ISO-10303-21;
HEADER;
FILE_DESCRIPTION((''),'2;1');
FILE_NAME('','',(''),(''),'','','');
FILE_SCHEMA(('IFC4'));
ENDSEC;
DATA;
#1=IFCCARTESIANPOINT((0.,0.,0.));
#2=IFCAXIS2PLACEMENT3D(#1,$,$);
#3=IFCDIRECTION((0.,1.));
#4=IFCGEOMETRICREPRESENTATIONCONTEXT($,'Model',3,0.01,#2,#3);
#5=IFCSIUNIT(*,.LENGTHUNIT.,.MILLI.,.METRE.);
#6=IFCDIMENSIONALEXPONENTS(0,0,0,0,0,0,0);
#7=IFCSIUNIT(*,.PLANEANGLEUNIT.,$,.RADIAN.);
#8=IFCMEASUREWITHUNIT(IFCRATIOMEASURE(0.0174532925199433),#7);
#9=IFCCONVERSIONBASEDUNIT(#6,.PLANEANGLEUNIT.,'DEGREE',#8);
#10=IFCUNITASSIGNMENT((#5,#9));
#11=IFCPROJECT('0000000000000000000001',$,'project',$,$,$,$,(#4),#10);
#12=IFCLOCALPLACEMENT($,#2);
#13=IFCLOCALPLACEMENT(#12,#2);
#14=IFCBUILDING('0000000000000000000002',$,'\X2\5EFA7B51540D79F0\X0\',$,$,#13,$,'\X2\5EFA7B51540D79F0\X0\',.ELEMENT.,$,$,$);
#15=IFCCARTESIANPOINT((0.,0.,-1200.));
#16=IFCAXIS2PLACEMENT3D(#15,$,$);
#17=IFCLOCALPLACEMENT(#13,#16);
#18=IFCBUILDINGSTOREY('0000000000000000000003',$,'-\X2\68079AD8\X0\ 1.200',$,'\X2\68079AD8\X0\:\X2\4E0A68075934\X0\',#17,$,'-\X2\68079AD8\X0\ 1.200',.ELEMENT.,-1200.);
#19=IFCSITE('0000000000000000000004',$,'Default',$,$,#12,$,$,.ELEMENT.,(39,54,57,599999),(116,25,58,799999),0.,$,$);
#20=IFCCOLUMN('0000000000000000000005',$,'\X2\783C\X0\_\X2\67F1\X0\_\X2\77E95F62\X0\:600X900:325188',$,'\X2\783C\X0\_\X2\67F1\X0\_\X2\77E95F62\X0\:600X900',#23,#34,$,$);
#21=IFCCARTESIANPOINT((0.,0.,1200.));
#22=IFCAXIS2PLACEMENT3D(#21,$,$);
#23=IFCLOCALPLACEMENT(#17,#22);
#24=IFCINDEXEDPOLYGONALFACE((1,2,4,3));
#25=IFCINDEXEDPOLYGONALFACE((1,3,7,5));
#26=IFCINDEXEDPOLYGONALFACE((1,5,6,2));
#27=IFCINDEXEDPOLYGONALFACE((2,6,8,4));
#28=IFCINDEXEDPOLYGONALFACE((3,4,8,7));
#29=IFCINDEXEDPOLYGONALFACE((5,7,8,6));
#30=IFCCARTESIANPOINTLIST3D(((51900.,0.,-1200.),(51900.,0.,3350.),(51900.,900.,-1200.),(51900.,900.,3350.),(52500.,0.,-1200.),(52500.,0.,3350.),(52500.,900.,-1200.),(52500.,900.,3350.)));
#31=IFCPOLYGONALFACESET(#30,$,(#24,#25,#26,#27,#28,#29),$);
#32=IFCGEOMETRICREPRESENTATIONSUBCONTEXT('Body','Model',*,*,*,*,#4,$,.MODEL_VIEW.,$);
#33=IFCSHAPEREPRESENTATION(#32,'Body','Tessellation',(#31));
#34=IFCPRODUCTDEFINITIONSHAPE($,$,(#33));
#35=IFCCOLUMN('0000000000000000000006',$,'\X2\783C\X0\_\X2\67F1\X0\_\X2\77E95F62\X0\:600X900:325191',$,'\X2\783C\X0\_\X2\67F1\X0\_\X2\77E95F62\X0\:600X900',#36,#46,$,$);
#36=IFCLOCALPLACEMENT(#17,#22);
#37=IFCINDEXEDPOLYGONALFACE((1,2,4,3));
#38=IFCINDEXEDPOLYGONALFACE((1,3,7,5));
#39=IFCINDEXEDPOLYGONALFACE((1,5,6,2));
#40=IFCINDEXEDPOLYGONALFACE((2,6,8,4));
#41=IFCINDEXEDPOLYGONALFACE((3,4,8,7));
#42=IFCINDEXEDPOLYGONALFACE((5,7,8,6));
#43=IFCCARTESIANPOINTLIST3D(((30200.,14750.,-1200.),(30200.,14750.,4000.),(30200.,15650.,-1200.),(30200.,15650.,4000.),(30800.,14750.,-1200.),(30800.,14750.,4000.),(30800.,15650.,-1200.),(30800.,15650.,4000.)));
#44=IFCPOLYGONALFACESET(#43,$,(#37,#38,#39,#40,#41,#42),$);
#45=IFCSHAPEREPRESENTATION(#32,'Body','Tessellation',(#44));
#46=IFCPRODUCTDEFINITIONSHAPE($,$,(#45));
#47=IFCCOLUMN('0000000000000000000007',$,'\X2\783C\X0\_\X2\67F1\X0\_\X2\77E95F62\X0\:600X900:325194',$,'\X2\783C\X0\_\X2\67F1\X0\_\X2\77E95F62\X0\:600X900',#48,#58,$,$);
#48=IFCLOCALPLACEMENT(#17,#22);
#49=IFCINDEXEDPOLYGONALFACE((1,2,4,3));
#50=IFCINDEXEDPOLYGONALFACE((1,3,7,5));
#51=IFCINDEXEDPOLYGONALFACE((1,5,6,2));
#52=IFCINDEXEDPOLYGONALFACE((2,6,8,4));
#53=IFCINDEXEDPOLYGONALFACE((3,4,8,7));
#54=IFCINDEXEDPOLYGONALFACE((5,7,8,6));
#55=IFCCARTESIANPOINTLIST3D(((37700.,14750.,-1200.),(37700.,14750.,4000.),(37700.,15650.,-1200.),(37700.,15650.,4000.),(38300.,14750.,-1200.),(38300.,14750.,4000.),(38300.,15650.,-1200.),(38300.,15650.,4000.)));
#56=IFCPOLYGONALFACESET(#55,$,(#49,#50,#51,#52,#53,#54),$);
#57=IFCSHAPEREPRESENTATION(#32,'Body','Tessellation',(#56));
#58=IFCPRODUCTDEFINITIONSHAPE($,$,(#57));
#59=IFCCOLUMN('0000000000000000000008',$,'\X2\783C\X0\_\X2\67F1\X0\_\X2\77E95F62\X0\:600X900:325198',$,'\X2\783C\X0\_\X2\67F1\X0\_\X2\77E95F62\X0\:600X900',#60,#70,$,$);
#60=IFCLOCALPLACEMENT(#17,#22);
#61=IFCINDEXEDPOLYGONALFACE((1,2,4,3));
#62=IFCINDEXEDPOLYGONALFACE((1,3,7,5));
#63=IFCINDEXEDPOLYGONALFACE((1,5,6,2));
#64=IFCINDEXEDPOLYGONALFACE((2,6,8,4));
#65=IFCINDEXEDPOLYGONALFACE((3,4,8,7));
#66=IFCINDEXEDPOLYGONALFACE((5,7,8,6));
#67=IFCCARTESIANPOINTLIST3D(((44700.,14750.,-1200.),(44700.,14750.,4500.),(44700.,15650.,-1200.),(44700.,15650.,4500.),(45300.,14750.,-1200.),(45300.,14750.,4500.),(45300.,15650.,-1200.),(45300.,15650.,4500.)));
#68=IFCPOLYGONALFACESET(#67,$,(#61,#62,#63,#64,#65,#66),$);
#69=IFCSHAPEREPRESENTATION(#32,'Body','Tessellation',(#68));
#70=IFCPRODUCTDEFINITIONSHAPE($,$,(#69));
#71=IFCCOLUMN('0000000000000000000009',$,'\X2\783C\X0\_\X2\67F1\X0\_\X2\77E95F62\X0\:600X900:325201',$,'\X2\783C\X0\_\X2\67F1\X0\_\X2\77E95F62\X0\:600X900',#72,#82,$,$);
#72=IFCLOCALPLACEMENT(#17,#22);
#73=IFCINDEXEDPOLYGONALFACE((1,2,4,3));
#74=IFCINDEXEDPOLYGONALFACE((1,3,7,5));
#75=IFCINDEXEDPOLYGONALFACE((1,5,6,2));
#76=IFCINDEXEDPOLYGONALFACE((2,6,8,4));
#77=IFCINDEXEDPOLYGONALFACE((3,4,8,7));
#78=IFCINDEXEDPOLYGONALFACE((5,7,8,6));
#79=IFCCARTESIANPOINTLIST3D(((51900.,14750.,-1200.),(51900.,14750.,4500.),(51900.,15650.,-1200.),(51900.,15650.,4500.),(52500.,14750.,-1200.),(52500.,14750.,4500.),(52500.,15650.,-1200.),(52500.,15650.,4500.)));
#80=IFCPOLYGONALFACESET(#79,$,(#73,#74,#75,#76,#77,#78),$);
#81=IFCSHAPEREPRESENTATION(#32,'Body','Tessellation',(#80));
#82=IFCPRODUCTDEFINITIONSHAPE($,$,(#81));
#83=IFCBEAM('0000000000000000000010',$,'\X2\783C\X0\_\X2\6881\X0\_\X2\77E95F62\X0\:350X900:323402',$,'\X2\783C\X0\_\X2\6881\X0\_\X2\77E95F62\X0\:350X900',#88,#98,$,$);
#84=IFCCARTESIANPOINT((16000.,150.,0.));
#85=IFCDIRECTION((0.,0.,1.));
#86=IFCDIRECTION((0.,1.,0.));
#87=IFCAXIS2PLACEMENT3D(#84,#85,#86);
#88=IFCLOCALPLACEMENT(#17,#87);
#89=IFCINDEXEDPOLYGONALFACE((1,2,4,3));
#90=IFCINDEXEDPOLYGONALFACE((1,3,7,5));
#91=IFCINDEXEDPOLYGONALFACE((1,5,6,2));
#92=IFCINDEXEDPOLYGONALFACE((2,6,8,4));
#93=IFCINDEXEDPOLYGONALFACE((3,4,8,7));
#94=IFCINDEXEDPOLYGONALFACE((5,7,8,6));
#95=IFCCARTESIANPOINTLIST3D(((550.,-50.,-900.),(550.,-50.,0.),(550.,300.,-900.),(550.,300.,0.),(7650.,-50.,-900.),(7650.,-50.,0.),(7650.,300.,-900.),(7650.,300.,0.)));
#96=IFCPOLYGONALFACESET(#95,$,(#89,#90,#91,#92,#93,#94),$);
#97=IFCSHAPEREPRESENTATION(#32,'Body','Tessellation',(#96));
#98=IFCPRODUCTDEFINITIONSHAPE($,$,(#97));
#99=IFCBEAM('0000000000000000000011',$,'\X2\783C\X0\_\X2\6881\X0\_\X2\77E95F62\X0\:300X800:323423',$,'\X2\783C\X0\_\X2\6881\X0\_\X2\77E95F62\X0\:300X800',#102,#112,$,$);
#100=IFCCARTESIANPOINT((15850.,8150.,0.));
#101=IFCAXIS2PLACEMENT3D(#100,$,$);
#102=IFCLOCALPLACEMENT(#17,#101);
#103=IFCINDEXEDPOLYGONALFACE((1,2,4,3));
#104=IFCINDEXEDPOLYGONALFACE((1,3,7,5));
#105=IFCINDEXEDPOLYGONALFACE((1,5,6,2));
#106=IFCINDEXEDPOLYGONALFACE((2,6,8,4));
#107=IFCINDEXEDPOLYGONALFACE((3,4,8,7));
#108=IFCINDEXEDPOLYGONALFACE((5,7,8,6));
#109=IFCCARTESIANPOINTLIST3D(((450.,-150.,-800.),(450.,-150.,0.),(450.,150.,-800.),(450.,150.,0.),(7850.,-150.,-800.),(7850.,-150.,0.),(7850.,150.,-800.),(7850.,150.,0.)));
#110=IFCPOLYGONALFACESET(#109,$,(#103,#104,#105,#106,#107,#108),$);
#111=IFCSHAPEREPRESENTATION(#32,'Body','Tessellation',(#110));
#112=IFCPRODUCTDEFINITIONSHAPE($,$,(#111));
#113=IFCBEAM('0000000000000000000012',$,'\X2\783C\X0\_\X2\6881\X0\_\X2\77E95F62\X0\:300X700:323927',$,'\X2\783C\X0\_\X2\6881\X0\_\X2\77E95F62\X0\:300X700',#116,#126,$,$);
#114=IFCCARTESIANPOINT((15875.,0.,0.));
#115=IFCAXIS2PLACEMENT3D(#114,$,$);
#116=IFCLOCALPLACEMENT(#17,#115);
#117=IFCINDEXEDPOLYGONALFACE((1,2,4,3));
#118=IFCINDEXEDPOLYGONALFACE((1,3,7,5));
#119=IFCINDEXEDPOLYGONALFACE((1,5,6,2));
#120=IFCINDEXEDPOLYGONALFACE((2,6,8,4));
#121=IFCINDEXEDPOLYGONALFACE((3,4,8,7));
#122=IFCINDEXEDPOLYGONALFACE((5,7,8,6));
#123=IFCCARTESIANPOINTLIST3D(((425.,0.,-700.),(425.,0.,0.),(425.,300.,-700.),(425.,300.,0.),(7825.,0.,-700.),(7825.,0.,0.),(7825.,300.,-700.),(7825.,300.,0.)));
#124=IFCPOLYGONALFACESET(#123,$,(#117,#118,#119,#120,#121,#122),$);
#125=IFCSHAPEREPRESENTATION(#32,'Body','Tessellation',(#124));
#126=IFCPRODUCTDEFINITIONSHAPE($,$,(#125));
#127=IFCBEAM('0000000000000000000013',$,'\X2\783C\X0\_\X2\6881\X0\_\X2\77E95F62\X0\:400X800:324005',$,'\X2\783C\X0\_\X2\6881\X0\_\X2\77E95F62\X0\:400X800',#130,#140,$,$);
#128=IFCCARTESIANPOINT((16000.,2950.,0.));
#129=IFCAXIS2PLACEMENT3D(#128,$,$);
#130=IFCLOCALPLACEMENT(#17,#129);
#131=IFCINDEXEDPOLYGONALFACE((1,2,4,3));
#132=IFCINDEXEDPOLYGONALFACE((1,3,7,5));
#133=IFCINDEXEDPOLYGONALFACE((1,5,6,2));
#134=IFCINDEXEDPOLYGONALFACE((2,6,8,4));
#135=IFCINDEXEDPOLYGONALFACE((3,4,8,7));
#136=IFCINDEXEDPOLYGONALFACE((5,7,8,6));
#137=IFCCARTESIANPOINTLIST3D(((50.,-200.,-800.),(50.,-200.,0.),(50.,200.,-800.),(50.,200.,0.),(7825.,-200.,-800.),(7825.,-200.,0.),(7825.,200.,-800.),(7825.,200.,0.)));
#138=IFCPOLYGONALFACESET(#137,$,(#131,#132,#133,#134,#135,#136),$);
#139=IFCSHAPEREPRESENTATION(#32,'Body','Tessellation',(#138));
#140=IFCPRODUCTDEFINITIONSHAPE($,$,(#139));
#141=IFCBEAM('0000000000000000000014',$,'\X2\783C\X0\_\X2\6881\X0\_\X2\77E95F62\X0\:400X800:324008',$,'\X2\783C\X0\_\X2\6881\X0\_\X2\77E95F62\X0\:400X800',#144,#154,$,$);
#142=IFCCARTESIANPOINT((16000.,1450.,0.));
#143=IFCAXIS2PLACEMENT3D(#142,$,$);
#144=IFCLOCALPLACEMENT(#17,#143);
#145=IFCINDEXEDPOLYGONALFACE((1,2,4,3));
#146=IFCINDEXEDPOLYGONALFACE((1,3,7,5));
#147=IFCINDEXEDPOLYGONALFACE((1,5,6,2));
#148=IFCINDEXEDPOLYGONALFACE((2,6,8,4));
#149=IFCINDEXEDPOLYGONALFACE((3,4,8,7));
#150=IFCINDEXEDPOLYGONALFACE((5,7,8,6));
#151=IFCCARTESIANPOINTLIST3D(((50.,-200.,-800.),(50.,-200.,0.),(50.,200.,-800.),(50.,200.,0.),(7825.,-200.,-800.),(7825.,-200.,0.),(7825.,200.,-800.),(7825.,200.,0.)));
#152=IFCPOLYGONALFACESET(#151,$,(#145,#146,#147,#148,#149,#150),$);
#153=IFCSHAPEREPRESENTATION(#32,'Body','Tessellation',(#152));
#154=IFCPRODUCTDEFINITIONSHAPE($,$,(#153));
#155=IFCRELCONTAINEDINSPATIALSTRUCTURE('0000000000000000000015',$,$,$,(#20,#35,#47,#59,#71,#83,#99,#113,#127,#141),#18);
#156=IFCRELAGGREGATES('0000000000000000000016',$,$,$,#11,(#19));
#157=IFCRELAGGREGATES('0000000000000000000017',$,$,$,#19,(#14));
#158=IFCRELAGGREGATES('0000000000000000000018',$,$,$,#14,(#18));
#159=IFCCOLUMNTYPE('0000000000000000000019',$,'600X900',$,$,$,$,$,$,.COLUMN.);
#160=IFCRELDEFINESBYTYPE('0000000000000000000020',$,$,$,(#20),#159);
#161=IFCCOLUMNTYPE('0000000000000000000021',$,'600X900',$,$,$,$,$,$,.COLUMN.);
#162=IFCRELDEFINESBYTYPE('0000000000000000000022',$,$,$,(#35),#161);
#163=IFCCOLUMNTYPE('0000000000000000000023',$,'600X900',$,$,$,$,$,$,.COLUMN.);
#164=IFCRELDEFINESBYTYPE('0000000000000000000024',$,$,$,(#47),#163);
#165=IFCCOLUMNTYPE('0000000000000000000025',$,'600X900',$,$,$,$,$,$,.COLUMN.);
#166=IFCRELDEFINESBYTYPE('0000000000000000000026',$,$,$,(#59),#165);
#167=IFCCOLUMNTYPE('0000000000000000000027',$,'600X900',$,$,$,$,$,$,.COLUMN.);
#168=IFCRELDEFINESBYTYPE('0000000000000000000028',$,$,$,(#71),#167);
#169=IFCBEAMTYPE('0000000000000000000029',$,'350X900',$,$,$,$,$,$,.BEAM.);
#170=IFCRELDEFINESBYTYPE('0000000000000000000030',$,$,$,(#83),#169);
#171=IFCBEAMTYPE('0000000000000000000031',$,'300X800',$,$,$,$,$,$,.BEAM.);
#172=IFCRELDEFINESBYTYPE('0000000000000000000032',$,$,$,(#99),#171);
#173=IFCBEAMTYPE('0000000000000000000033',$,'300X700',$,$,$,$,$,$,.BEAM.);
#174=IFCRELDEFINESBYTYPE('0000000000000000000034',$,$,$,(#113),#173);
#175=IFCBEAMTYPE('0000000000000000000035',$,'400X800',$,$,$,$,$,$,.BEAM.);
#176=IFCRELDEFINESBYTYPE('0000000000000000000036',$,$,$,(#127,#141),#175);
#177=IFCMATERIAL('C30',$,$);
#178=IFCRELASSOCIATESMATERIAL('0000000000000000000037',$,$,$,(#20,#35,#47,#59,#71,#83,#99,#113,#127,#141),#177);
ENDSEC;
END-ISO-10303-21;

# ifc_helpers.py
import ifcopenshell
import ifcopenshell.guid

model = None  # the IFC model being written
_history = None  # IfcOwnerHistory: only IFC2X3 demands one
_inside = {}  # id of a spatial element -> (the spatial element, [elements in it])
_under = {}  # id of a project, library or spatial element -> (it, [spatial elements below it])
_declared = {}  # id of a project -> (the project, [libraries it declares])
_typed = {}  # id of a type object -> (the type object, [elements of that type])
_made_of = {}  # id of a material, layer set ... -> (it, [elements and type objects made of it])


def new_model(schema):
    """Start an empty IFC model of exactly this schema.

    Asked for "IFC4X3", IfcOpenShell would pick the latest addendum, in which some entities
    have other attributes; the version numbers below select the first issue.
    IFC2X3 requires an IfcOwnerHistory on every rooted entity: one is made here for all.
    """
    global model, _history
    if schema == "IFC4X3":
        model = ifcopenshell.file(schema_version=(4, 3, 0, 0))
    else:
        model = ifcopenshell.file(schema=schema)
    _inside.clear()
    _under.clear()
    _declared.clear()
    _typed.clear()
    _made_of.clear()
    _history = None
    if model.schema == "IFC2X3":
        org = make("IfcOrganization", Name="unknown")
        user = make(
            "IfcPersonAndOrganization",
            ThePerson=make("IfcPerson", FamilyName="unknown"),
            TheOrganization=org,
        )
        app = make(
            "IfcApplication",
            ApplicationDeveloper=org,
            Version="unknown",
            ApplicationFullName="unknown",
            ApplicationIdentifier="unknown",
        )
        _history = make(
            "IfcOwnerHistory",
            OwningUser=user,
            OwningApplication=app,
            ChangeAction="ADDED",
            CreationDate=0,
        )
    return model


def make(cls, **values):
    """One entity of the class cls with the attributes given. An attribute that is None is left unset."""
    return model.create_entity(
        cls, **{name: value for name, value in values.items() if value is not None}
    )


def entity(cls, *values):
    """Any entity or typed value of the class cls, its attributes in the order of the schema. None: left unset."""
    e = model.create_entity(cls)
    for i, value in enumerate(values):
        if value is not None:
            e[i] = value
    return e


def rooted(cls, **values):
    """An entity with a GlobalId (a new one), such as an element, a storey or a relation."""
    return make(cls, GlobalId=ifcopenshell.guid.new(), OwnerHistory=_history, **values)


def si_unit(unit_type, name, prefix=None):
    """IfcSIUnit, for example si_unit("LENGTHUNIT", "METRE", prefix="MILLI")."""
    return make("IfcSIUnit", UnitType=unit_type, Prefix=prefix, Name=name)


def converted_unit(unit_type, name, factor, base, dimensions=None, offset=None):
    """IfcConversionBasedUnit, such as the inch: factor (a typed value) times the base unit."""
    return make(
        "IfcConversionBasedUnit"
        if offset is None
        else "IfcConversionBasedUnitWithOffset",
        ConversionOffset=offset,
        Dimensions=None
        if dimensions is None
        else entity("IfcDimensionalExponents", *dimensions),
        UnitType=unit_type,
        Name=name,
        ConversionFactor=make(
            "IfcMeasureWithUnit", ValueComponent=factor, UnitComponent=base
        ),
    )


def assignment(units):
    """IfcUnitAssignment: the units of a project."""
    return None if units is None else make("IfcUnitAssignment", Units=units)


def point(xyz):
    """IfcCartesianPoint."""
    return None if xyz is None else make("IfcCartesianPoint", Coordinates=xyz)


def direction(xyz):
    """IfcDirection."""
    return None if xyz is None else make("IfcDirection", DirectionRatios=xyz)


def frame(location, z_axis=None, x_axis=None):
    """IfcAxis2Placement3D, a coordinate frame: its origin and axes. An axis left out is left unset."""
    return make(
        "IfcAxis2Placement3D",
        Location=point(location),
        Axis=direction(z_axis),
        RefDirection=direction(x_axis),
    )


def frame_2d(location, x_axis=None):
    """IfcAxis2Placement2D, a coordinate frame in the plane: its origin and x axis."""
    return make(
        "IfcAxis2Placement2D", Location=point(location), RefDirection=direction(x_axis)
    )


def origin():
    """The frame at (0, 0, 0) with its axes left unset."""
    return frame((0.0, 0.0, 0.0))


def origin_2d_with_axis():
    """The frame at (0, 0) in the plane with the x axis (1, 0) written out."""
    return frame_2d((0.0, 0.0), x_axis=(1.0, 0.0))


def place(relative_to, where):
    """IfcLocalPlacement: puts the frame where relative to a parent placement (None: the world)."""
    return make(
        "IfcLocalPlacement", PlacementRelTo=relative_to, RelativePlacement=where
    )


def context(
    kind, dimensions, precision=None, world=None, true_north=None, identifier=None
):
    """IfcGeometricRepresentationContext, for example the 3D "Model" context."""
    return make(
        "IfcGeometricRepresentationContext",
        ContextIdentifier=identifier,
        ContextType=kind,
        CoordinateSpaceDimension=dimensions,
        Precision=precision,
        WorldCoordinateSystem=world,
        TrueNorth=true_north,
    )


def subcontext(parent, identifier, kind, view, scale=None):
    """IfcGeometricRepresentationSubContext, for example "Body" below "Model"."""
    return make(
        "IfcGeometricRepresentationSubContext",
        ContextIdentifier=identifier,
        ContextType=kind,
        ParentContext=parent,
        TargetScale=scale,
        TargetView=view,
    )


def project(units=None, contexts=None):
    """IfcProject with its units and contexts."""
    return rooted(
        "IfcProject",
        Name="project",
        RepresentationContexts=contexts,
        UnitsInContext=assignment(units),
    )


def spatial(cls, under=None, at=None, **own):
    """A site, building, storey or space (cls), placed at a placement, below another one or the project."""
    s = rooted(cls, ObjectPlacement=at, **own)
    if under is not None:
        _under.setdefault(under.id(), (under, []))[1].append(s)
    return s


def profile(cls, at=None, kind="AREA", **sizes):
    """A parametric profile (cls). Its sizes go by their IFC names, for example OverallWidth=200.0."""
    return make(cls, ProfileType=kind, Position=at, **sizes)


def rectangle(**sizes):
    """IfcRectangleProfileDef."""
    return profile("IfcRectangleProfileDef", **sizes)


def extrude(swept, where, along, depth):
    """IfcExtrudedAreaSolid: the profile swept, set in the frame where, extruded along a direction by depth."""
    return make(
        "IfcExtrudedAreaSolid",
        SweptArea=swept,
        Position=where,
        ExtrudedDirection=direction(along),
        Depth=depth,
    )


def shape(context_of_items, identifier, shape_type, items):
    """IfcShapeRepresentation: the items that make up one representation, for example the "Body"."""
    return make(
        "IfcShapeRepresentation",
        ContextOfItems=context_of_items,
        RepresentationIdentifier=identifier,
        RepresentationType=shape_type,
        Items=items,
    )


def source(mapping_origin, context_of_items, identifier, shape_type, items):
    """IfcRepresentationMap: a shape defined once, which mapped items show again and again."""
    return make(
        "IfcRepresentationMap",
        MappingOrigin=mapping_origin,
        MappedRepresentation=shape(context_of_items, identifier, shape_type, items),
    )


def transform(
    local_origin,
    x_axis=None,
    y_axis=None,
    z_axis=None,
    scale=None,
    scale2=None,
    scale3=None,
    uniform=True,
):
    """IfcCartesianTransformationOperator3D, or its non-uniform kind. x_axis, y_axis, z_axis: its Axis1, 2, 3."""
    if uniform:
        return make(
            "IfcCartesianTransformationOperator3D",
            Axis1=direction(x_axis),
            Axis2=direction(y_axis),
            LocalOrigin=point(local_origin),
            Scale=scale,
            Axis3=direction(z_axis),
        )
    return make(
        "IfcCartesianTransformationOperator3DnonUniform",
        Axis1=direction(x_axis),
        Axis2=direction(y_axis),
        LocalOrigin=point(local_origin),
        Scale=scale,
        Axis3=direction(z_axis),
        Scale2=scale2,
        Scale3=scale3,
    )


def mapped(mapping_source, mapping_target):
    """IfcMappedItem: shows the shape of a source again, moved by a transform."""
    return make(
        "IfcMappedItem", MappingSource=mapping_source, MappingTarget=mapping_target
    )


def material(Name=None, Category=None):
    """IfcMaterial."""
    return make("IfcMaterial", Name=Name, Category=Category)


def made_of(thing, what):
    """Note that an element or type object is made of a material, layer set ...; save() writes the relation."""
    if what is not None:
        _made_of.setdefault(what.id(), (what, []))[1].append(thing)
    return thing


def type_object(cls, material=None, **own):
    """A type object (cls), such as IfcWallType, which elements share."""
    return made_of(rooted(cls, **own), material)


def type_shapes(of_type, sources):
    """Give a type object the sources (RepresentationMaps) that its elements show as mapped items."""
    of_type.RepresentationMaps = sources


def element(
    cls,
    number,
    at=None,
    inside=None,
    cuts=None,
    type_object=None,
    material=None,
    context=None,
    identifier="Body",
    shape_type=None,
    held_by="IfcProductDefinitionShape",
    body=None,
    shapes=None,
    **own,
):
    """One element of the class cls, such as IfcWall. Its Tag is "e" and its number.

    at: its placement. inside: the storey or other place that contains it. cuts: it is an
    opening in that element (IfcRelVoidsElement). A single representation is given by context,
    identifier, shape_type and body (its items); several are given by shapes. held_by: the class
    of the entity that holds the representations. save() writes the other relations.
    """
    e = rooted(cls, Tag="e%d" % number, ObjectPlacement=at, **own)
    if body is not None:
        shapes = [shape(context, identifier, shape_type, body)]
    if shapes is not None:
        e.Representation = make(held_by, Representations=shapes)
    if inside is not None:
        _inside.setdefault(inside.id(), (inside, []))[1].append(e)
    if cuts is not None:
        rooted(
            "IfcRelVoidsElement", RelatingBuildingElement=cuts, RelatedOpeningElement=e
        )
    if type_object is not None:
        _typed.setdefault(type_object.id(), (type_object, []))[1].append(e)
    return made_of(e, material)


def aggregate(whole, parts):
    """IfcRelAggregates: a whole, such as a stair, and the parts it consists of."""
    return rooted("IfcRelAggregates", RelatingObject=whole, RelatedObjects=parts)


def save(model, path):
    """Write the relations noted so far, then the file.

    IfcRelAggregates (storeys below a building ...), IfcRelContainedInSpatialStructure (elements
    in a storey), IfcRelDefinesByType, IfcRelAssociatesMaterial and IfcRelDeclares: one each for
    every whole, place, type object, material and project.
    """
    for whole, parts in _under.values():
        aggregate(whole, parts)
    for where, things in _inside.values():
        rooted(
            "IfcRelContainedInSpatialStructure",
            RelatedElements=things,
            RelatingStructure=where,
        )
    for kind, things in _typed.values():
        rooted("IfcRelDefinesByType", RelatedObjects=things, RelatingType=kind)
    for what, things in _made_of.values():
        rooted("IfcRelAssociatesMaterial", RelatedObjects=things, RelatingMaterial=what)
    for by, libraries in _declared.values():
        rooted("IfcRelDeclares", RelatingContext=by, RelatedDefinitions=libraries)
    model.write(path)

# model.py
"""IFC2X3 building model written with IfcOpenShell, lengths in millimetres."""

from ifc_helpers import new_model, entity, si_unit, converted_unit, direction, frame, frame_2d, origin, origin_2d_with_axis, place, context, subcontext, project, spatial, rectangle, extrude, source, transform, mapped, material, type_object, type_shapes, element, save


model = new_model("IFC2X3")

# Units and contexts
model_context = context("Model", 3, precision=0.01, world=origin(), true_north=direction((0.0, 1.0)))
body_context = subcontext(model_context, "Body", "Model", "MODEL_VIEW")
ifc_project = project(units=[si_unit("LENGTHUNIT", "METRE", prefix="MILLI"), converted_unit("PLANEANGLEUNIT", "DEGREE", entity("IfcRatioMeasure", 0.0174532925199433), si_unit("PLANEANGLEUNIT", "RADIAN"), dimensions=[0, 0, 0, 0, 0, 0, 0])], contexts=[model_context])

# Site, building, storey
site_placement = place(None, origin())
site = spatial("IfcSite", under=ifc_project, at=site_placement, Name="Default", CompositionType="ELEMENT", RefLatitude=(39, 54, 57, 599999), RefLongitude=(116, 25, 58, 799999), RefElevation=0.0)
building_placement = place(site_placement, origin())
building = spatial("IfcBuilding", under=site, at=building_placement, Name="建筑名称", LongName="建筑名称", CompositionType="ELEMENT")
storey_placement = place(building_placement, frame((0.0, 0.0, -1200.0)))
storey = spatial("IfcBuildingStorey", under=building, at=storey_placement, Name="-标高 1.200", ObjectType="标高:上标头", LongName="-标高 1.200", CompositionType="ELEMENT", Elevation=-1200.0)

# Columns
ifc_material_1 = material(Name="C30")
column_type_1 = type_object("IfcColumnType", Name="600X900", PredefinedType="COLUMN")
shared_shape_1 = source(origin(), body_context, "Body", "SweptSolid", [
    extrude(rectangle(XDim=900.0, YDim=600.0, at=origin_2d_with_axis()), frame((52200.0, 450.0, -1200.0), z_axis=(0.0, 0.0, 1.0), x_axis=(0.0, -1.0, 0.0)), (0.0, 0.0, 1.0), 4550.0),
])
type_shapes(column_type_1, [shared_shape_1])
column_1_placement = place(storey_placement, frame((0.0, 0.0, 1200.0)))
element("IfcColumn", 1, at=column_1_placement, inside=storey, type_object=column_type_1, material=ifc_material_1, Name="砼_柱_矩形:600X900:325188", ObjectType="砼_柱_矩形:600X900", context=body_context, shape_type="MappedRepresentation", body=[
    mapped(shared_shape_1, transform((0.0, 0.0, 0.0), scale=1.0)),
])
column_type_2 = type_object("IfcColumnType", Name="600X900", PredefinedType="COLUMN")
shared_shape_2 = source(origin(), body_context, "Body", "SweptSolid", [
    extrude(rectangle(XDim=900.0, YDim=600.0, at=origin_2d_with_axis()), frame((30500.0, 15200.0, -1200.0), z_axis=(0.0, 0.0, 1.0), x_axis=(0.0, -1.0, 0.0)), (0.0, 0.0, 1.0), 5200.0),
])
type_shapes(column_type_2, [shared_shape_2])
column_2_placement = place(storey_placement, frame((0.0, 0.0, 1200.0)))
element("IfcColumn", 2, at=column_2_placement, inside=storey, type_object=column_type_2, material=ifc_material_1, Name="砼_柱_矩形:600X900:325191", ObjectType="砼_柱_矩形:600X900", context=body_context, shape_type="MappedRepresentation", body=[
    mapped(shared_shape_2, transform((0.0, 0.0, 0.0), scale=1.0)),
])
column_type_3 = type_object("IfcColumnType", Name="600X900", PredefinedType="COLUMN")
shared_shape_3 = source(origin(), body_context, "Body", "SweptSolid", [
    extrude(rectangle(XDim=900.0, YDim=600.0, at=origin_2d_with_axis()), frame((38000.0, 15200.0, -1200.0), z_axis=(0.0, 0.0, 1.0), x_axis=(0.0, -1.0, 0.0)), (0.0, 0.0, 1.0), 5200.0),
])
type_shapes(column_type_3, [shared_shape_3])
column_3_placement = place(storey_placement, frame((0.0, 0.0, 1200.0)))
element("IfcColumn", 3, at=column_3_placement, inside=storey, type_object=column_type_3, material=ifc_material_1, Name="砼_柱_矩形:600X900:325194", ObjectType="砼_柱_矩形:600X900", context=body_context, shape_type="MappedRepresentation", body=[
    mapped(shared_shape_3, transform((0.0, 0.0, 0.0), scale=1.0)),
])
column_type_4 = type_object("IfcColumnType", Name="600X900", PredefinedType="COLUMN")
shared_shape_4 = source(origin(), body_context, "Body", "SweptSolid", [
    extrude(rectangle(XDim=900.0, YDim=600.0, at=origin_2d_with_axis()), frame((45000.0, 15200.0, -1200.0), z_axis=(0.0, 0.0, 1.0), x_axis=(0.0, -1.0, 0.0)), (0.0, 0.0, 1.0), 5700.0),
])
type_shapes(column_type_4, [shared_shape_4])
column_4_placement = place(storey_placement, frame((0.0, 0.0, 1200.0)))
element("IfcColumn", 4, at=column_4_placement, inside=storey, type_object=column_type_4, material=ifc_material_1, Name="砼_柱_矩形:600X900:325198", ObjectType="砼_柱_矩形:600X900", context=body_context, shape_type="MappedRepresentation", body=[
    mapped(shared_shape_4, transform((0.0, 0.0, 0.0), scale=1.0)),
])
column_type_5 = type_object("IfcColumnType", Name="600X900", PredefinedType="COLUMN")
shared_shape_5 = source(origin(), body_context, "Body", "SweptSolid", [
    extrude(rectangle(XDim=900.0, YDim=600.0, at=origin_2d_with_axis()), frame((52200.0, 15200.0, -1200.0), z_axis=(0.0, 0.0, 1.0), x_axis=(0.0, -1.0, 0.0)), (0.0, 0.0, 1.0), 5700.0),
])
type_shapes(column_type_5, [shared_shape_5])
column_5_placement = place(storey_placement, frame((0.0, 0.0, 1200.0)))
element("IfcColumn", 5, at=column_5_placement, inside=storey, type_object=column_type_5, material=ifc_material_1, Name="砼_柱_矩形:600X900:325201", ObjectType="砼_柱_矩形:600X900", context=body_context, shape_type="MappedRepresentation", body=[
    mapped(shared_shape_5, transform((0.0, 0.0, 0.0), scale=1.0)),
])

# Beams
beam_type_1 = type_object("IfcBeamType", Name="350X900", PredefinedType="BEAM")
beam_1_placement = place(storey_placement, frame((16000.0, 150.0, 0.0), z_axis=(0.0, 0.0, 1.0), x_axis=(0.0, 1.0, 0.0)))
element("IfcBeam", 6, at=beam_1_placement, inside=storey, type_object=beam_type_1, material=ifc_material_1, Name="砼_梁_矩形:350X900:323402", ObjectType="砼_梁_矩形:350X900", context=body_context, shape_type="SweptSolid", body=[
    extrude(rectangle(XDim=900.0, YDim=350.0, at=frame_2d((0.0, 0.0), x_axis=(1.0, 0.0))), frame((550.0, 125.0, -450.0), z_axis=(1.0, 0.0, 0.0), x_axis=(0.0, 0.0, -1.0)), (0.0, 0.0, 1.0), 7100.0),
])
beam_type_2 = type_object("IfcBeamType", Name="300X800", PredefinedType="BEAM")
beam_2_placement = place(storey_placement, frame((15850.0, 8150.0, 0.0)))
element("IfcBeam", 7, at=beam_2_placement, inside=storey, type_object=beam_type_2, material=ifc_material_1, Name="砼_梁_矩形:300X800:323423", ObjectType="砼_梁_矩形:300X800", context=body_context, shape_type="SweptSolid", body=[
    extrude(rectangle(XDim=800.0, YDim=300.0, at=frame_2d((0.0, 0.0), x_axis=(1.0, 0.0))), frame((450.0, 0.0, -400.0), z_axis=(1.0, 0.0, 0.0), x_axis=(0.0, 0.0, -1.0)), (0.0, 0.0, 1.0), 7400.0),
])
beam_type_3 = type_object("IfcBeamType", Name="300X700", PredefinedType="BEAM")
beam_3_placement = place(storey_placement, frame((15875.0, 0.0, 0.0)))
element("IfcBeam", 8, at=beam_3_placement, inside=storey, type_object=beam_type_3, material=ifc_material_1, Name="砼_梁_矩形:300X700:323927", ObjectType="砼_梁_矩形:300X700", context=body_context, shape_type="SweptSolid", body=[
    extrude(rectangle(XDim=700.0, YDim=300.0, at=frame_2d((0.0, 0.0), x_axis=(1.0, 0.0))), frame((425.0, 150.0, -350.0), z_axis=(1.0, 0.0, 0.0), x_axis=(0.0, 0.0, -1.0)), (0.0, 0.0, 1.0), 7400.0),
])
beam_type_4 = type_object("IfcBeamType", Name="400X800", PredefinedType="BEAM")
for number, where, name in (
    (9, (16000.0, 2950.0, 0.0), "砼_梁_矩形:400X800:324005"),
    (10, (16000.0, 1450.0, 0.0), "砼_梁_矩形:400X800:324008"),
):
    element("IfcBeam", number, at=place(storey_placement, frame(where)), inside=storey, type_object=beam_type_4, material=ifc_material_1, Name=name, ObjectType="砼_梁_矩形:400X800", context=body_context, shape_type="SweptSolid", body=[
        extrude(rectangle(XDim=800.0, YDim=400.0, at=frame_2d((0.0, 0.0), x_axis=(1.0, 0.0))), frame((50.0, 0.0, -400.0), z_axis=(1.0, 0.0, 0.0), x_axis=(0.0, 0.0, -1.0)), (0.0, 0.0, 1.0), 7775.0),
    ])

save(model, "model.ifc")
